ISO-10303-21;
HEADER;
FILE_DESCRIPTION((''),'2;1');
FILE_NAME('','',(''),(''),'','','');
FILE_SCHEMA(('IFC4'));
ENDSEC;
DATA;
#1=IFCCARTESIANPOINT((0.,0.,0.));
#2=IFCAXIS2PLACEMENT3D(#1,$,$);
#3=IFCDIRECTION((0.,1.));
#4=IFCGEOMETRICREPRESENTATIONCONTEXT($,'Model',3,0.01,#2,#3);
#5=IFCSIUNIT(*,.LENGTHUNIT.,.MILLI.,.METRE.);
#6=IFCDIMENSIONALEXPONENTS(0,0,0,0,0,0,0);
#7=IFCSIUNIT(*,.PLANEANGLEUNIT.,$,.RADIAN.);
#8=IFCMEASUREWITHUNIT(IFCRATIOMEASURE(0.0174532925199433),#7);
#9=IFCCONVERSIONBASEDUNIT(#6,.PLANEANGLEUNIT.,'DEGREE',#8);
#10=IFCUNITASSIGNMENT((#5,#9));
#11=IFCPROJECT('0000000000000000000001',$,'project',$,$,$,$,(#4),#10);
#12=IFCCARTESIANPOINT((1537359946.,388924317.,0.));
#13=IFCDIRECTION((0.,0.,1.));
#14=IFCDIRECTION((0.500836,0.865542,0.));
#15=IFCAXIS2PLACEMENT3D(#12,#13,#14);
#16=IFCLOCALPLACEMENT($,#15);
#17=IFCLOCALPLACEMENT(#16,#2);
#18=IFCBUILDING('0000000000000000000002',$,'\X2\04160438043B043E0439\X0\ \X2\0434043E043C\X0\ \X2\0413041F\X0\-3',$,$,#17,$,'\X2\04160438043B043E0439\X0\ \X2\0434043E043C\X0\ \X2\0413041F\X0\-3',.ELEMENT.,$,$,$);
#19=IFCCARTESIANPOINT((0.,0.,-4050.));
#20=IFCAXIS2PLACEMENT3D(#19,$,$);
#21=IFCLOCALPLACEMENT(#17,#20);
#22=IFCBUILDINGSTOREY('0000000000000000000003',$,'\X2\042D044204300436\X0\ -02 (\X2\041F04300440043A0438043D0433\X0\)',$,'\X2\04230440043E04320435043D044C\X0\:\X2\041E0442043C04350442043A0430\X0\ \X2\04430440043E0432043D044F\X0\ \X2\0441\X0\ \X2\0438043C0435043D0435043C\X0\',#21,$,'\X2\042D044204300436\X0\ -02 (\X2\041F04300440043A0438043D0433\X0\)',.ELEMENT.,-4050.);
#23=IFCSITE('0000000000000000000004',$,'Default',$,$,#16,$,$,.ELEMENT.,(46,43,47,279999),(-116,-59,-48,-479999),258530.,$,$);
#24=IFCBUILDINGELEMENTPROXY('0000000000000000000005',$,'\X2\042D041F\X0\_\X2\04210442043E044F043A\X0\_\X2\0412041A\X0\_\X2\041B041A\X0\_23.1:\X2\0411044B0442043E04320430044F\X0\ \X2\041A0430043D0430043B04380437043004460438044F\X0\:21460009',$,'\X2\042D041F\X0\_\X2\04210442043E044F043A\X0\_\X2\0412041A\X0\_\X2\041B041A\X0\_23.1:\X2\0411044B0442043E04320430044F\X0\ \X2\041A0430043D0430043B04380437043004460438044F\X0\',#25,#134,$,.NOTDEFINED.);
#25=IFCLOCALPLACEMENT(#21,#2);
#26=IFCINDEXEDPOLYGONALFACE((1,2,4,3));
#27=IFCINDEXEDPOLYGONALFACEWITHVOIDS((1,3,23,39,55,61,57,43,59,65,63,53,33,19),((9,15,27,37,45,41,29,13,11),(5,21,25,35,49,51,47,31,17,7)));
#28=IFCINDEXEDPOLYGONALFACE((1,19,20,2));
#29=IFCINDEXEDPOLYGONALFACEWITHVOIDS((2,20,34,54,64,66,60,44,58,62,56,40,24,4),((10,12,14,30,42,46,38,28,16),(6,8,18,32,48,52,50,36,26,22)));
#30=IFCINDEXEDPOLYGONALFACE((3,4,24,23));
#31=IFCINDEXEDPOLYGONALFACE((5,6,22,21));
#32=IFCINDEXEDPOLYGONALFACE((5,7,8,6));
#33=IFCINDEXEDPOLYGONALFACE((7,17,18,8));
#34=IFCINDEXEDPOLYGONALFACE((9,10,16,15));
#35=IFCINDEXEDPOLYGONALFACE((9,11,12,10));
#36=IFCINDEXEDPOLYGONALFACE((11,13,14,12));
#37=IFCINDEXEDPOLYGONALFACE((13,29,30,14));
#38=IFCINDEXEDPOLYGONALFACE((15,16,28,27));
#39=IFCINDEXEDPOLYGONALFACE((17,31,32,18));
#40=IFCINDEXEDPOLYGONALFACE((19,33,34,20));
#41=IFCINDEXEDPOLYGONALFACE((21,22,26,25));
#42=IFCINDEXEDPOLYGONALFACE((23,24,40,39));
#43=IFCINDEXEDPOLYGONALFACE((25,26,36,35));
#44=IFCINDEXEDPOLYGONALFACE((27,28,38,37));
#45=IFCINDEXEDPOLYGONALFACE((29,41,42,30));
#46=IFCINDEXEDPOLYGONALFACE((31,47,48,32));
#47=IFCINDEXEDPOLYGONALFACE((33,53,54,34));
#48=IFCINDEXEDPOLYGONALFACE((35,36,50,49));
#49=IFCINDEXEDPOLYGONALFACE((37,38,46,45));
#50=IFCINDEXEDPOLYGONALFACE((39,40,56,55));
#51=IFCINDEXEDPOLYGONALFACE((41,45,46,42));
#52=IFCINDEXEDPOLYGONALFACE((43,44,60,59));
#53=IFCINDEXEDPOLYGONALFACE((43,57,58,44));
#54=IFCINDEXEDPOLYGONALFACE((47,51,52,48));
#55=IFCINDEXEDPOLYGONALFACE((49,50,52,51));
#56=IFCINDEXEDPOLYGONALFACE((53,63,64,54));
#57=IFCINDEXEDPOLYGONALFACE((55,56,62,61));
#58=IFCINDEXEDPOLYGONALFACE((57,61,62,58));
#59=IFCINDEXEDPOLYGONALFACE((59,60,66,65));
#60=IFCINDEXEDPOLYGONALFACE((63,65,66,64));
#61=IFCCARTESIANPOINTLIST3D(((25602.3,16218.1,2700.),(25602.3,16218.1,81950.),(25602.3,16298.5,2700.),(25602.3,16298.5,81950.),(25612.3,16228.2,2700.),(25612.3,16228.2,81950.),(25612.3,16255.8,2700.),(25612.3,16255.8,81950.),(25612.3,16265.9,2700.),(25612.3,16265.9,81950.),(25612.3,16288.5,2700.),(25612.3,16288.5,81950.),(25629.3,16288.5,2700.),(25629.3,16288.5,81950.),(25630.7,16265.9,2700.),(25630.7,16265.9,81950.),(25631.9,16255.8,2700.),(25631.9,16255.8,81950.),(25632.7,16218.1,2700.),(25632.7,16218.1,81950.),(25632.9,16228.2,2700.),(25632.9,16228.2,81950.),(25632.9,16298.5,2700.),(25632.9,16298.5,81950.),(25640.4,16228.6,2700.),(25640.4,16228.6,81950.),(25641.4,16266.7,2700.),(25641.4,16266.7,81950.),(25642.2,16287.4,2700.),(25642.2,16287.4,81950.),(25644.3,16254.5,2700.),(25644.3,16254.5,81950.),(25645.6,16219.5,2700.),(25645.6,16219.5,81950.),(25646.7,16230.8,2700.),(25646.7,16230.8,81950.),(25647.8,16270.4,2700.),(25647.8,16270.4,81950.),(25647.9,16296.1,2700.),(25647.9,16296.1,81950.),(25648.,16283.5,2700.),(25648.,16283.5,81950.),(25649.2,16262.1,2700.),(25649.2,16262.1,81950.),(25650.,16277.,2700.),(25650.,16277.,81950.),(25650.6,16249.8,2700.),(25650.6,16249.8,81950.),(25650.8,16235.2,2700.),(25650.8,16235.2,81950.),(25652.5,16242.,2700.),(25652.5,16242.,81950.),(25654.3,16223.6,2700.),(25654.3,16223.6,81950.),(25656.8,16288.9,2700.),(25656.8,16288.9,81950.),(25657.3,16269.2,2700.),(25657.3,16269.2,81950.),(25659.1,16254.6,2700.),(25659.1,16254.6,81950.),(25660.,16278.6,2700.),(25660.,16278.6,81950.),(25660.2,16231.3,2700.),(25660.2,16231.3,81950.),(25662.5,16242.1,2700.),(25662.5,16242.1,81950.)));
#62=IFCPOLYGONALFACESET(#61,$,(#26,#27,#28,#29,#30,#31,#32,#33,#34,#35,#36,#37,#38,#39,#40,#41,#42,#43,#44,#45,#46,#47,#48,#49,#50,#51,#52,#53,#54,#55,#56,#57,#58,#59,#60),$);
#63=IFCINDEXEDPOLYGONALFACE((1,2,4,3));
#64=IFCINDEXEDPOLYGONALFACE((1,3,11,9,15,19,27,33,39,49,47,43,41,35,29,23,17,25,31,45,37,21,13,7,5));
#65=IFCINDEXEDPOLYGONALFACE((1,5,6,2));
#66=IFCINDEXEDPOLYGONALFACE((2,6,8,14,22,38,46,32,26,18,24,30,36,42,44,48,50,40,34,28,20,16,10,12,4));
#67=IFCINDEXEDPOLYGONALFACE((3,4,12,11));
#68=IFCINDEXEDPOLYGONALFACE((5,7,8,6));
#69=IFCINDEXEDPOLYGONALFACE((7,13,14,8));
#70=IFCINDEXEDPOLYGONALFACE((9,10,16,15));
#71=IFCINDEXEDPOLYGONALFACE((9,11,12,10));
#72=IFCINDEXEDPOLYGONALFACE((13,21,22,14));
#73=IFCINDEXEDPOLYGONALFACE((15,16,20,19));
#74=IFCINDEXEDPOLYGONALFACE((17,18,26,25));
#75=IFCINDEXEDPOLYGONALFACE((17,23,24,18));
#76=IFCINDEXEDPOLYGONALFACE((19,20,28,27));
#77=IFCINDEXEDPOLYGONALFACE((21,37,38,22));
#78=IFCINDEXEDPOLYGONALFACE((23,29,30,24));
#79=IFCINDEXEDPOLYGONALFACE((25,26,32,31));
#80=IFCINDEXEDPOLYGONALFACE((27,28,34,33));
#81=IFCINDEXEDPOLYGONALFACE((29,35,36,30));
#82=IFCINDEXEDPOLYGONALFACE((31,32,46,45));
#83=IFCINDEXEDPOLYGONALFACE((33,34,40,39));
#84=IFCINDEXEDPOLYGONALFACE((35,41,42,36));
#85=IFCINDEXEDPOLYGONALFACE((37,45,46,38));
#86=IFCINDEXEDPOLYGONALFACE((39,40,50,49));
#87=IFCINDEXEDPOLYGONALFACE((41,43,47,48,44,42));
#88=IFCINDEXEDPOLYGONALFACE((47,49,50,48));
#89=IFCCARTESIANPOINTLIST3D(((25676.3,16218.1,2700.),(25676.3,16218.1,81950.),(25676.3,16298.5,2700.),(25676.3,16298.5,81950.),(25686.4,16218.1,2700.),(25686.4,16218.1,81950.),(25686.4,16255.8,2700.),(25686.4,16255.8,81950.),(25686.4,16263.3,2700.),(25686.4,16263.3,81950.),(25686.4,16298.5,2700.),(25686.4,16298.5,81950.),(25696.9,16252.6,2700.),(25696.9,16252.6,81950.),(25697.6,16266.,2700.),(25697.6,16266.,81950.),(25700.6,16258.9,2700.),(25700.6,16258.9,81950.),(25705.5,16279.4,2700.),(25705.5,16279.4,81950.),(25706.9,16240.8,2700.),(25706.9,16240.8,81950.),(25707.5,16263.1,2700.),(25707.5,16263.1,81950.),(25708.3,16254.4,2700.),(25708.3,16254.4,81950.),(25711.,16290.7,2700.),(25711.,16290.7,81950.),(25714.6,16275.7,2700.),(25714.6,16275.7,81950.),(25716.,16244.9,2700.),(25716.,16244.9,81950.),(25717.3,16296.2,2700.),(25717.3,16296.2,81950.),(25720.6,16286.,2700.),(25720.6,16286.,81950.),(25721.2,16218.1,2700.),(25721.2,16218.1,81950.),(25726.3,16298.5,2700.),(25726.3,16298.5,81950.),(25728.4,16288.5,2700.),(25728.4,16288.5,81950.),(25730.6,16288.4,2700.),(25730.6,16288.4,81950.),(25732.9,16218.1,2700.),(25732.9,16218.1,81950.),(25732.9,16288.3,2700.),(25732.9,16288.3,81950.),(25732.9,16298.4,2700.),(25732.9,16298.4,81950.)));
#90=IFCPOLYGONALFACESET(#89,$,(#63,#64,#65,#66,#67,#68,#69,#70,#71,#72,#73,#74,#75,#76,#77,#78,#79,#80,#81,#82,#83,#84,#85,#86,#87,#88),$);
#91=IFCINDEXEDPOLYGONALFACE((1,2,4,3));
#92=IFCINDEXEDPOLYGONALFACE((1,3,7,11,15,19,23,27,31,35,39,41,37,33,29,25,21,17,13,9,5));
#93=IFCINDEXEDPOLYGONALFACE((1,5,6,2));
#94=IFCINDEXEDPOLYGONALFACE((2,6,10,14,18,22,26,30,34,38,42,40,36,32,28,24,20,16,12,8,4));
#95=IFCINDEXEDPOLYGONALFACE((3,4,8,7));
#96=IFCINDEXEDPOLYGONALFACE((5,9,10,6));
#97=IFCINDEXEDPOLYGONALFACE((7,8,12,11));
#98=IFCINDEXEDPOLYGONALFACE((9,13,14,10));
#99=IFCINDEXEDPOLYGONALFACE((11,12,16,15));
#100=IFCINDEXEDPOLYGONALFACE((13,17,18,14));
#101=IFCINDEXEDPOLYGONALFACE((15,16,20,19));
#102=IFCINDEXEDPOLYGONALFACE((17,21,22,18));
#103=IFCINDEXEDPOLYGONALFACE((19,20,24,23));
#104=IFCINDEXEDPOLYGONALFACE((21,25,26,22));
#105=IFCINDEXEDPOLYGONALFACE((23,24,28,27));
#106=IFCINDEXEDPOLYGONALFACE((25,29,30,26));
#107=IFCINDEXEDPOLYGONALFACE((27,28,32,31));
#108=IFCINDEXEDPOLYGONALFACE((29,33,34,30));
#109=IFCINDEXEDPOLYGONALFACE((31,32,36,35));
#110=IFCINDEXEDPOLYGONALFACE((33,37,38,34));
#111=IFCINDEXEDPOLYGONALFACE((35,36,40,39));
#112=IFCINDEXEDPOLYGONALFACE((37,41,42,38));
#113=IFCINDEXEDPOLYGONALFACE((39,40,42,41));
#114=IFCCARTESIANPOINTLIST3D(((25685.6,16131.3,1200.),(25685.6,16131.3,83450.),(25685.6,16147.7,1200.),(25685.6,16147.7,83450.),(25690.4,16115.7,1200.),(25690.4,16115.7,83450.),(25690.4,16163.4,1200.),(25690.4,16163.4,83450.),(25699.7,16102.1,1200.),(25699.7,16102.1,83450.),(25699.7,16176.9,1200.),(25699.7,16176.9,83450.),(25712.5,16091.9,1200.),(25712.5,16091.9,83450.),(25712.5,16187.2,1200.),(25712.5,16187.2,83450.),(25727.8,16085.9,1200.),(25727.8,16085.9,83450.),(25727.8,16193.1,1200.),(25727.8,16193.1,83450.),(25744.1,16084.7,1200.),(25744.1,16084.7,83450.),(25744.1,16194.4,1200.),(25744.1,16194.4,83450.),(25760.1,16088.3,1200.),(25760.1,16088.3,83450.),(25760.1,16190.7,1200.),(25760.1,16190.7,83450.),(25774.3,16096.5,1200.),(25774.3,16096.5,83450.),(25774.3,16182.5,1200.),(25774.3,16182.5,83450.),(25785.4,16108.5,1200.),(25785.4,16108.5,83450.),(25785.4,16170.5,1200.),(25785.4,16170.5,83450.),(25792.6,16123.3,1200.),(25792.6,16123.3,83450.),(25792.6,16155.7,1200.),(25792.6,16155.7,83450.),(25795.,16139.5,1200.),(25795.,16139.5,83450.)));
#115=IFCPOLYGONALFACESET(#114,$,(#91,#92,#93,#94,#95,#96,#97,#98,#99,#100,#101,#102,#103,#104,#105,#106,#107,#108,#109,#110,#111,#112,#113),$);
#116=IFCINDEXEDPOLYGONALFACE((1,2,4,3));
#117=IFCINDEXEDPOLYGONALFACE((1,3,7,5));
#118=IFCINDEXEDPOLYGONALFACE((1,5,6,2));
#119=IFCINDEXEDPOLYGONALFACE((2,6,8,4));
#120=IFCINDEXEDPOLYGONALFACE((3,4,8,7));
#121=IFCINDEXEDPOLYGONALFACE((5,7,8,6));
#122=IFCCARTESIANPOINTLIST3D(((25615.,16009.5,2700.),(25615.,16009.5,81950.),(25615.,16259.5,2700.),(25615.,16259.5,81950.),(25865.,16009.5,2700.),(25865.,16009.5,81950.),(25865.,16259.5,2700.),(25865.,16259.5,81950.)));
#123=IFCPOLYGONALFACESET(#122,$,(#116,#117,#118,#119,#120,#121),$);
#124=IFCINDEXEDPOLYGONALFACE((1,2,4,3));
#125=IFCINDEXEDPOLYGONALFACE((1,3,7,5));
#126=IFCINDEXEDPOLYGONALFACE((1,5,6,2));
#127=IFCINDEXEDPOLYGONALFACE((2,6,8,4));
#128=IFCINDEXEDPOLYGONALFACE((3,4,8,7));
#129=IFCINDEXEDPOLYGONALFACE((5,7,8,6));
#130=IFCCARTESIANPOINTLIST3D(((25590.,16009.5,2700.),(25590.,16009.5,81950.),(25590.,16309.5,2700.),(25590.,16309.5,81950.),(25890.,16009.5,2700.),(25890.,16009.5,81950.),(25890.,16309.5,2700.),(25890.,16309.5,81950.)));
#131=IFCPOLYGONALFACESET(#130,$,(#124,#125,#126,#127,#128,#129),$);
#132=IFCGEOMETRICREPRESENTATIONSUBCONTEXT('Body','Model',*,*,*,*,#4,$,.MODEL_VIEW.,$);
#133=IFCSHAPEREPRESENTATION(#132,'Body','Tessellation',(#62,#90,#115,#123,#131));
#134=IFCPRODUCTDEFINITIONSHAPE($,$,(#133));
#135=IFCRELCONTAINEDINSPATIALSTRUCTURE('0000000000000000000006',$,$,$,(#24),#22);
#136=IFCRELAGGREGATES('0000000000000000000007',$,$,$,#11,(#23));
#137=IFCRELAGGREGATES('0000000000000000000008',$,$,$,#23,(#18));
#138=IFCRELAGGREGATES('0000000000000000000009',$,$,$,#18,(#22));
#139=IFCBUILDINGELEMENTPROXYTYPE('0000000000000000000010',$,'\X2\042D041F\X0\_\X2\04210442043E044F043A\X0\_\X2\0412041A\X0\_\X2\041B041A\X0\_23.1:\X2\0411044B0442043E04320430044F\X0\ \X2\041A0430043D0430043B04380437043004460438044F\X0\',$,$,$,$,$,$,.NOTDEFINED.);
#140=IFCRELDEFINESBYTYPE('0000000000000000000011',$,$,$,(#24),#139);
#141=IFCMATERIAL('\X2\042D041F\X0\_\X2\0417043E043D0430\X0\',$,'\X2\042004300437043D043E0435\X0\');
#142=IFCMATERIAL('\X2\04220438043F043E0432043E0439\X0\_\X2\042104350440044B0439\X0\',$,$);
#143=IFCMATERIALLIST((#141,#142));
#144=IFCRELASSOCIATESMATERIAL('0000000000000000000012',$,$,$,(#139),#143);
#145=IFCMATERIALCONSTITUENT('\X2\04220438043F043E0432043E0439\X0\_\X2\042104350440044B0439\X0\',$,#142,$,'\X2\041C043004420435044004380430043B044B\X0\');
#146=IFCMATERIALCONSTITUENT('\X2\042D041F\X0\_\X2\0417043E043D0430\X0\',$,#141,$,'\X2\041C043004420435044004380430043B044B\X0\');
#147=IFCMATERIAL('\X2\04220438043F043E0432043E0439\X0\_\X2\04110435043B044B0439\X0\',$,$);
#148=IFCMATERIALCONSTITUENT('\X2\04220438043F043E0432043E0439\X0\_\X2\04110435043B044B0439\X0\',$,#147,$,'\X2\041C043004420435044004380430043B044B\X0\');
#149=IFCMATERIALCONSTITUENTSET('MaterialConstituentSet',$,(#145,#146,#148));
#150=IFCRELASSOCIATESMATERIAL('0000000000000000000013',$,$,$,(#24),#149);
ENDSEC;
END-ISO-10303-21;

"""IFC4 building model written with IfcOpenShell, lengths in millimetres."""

from ifc_helpers import new_model, entity, si_unit, converted_unit, direction, frame, frame_2d, origin, place, context, subcontext, project, spatial, polyline, rectangle, circle, outline, extrude, source, transform, mapped, material, material_list, constituent, constituent_set, type_object, type_shapes, element, save


model = new_model("IFC4")

# Units and contexts
model_context = context("Model", 3, precision=0.01, world=origin(), true_north=direction((0.0, 1.0)))
body_context = subcontext(model_context, "Body", "Model", "MODEL_VIEW")
ifc_project = project(units=[si_unit("LENGTHUNIT", "METRE", prefix="MILLI"), converted_unit("PLANEANGLEUNIT", "DEGREE", entity("IfcRatioMeasure", 0.0174532925199433), si_unit("PLANEANGLEUNIT", "RADIAN"), dimensions=[0, 0, 0, 0, 0, 0, 0])], contexts=[model_context])

# Site, building, storey
site_placement = place(None, frame((1537359946.0, 388924317.0, 0.0), z_axis=(0.0, 0.0, 1.0), x_axis=(0.500836, 0.865542, 0.0)))
site = spatial("IfcSite", under=ifc_project, at=site_placement, Name="Default", CompositionType="ELEMENT", RefLatitude=(46, 43, 47, 279999), RefLongitude=(-116, -59, -48, -479999), RefElevation=258530.0)
building_placement = place(site_placement, origin())
building = spatial("IfcBuilding", under=site, at=building_placement, Name="Жилой дом ГП-3", LongName="Жилой дом ГП-3", CompositionType="ELEMENT")
storey_placement = place(building_placement, frame((0.0, 0.0, -4050.0)))
storey = spatial("IfcBuildingStorey", under=building, at=storey_placement, Name="Этаж -02 (Паркинг)", ObjectType="Уровень:Отметка уровня с именем", LongName="Этаж -02 (Паркинг)", CompositionType="ELEMENT", Elevation=-4050.0)

# Building element proxy
ifc_material_1 = material(Name="ЭП_Зона", Category="Разное")
ifc_material_2 = material(Name="Типовой_Белый")
ifc_material_3 = material(Name="Типовой_Серый")
ifc_material_list_1 = material_list([ifc_material_1, ifc_material_3])
building_element_proxy_type_1 = type_object("IfcBuildingElementProxyType", Name="ЭП_Стояк_ВК_ЛК_23.1:Бытовая Канализация", PredefinedType="NOTDEFINED", material=ifc_material_list_1)
shared_shape_1 = source(origin(), body_context, "Body", "SweptSolid", [
    extrude(outline(polyline([(-42.2, -39.0), (-11.8, -39.0), (1.1, -37.6), (9.8, -33.5), (15.7, -25.8), (18.0, -15.0), (14.6, -2.5), (4.7, 5.0), (12.8, 12.1), (15.5, 21.5), (12.3, 31.8), (3.4, 39.0), (-11.6, 41.4), (-42.2, 41.4), (-42.2, -39.0)]), holes=[polyline([(-32.2, 8.8), (-32.2, 31.4), (-15.2, 31.4), (-2.3, 30.3), (3.5, 26.4), (5.5, 19.9), (3.3, 13.3), (-3.1, 9.6), (-13.9, 8.8), (-32.2, 8.8)]), polyline([(-32.2, -28.9), (-32.2, -1.3), (-12.6, -1.3), (-0.2, -2.6), (6.1, -7.3), (8.0, -15.1), (6.3, -21.9), (2.2, -26.3), (-4.1, -28.5), (-11.6, -28.9), (-32.2, -28.9)])]), frame((54.5, -52.4, -1350.0)), (0.0, 0.0, 1.0), 79250.0),
    extrude(outline(polyline([(-32.1, -31.9), (48.3, -31.9), (48.3, -21.8), (10.6, -21.8), (13.8, -11.4), (25.6, -1.3), (48.3, 13.0), (48.3, 24.6), (21.4, 7.7), (12.0, 0.1), (7.4, -7.7), (3.3, -0.7), (-9.3, 6.4), (-19.7, 12.3), (-22.1, 20.2), (-22.0, 22.4), (-22.0, 24.6), (-32.0, 24.6), (-32.1, 18.0), (-29.9, 9.0), (-24.3, 2.8), (-13.1, -2.8), (0.4, -10.6), (3.0, -21.8), (-32.1, -21.8), (-32.1, -31.9)])), frame((118.2, -43.1, -1350.0), z_axis=(0.0, 0.0, 1.0), x_axis=(0.0, -1.0, 0.0)), (0.0, 0.0, 1.0), 79250.0),
    extrude(circle(Radius=55.0, at=frame_2d((0.0, 0.0), x_axis=(1.0, 0.0))), frame((150.0, -170.0, -2850.0)), (0.0, 0.0, 1.0), 82250.0),
    extrude(rectangle(XDim=250.0, YDim=250.0, at=frame_2d((0.0, 0.0), x_axis=(1.0, 0.0))), frame((150.0, -175.0, -1350.0)), (0.0, 0.0, 1.0), 79250.0),
    extrude(rectangle(XDim=300.0, YDim=300.0, at=frame_2d((0.0, 0.0), x_axis=(1.0, 0.0))), frame((150.0, -150.0, -1350.0)), (0.0, 0.0, 1.0), 79250.0),
])
type_shapes(building_element_proxy_type_1, [shared_shape_1])
ifc_constituent_1 = constituent(ifc_material_3, Name="Типовой_Серый", Category="Материалы")
ifc_constituent_2 = constituent(ifc_material_1, Name="ЭП_Зона", Category="Материалы")
ifc_constituent_3 = constituent(ifc_material_2, Name="Типовой_Белый", Category="Материалы")
ifc_constituent_set_1 = constituent_set(constituents=[ifc_constituent_1, ifc_constituent_2, ifc_constituent_3], Name="MaterialConstituentSet")
proxy_1_placement = place(storey_placement, frame((25590.0, 16309.5, 4050.0)))
element("IfcBuildingElementProxy", 1, at=proxy_1_placement, inside=storey, type_object=building_element_proxy_type_1, material=ifc_constituent_set_1, Name="ЭП_Стояк_ВК_ЛК_23.1:Бытовая Канализация:21460009", ObjectType="ЭП_Стояк_ВК_ЛК_23.1:Бытовая Канализация", PredefinedType="NOTDEFINED", context=body_context, shape_type="MappedRepresentation", body=[
    mapped(shared_shape_1, transform((0.0, 0.0, 0.0), scale=1.0)),
])

save(model, "model.ifc")
